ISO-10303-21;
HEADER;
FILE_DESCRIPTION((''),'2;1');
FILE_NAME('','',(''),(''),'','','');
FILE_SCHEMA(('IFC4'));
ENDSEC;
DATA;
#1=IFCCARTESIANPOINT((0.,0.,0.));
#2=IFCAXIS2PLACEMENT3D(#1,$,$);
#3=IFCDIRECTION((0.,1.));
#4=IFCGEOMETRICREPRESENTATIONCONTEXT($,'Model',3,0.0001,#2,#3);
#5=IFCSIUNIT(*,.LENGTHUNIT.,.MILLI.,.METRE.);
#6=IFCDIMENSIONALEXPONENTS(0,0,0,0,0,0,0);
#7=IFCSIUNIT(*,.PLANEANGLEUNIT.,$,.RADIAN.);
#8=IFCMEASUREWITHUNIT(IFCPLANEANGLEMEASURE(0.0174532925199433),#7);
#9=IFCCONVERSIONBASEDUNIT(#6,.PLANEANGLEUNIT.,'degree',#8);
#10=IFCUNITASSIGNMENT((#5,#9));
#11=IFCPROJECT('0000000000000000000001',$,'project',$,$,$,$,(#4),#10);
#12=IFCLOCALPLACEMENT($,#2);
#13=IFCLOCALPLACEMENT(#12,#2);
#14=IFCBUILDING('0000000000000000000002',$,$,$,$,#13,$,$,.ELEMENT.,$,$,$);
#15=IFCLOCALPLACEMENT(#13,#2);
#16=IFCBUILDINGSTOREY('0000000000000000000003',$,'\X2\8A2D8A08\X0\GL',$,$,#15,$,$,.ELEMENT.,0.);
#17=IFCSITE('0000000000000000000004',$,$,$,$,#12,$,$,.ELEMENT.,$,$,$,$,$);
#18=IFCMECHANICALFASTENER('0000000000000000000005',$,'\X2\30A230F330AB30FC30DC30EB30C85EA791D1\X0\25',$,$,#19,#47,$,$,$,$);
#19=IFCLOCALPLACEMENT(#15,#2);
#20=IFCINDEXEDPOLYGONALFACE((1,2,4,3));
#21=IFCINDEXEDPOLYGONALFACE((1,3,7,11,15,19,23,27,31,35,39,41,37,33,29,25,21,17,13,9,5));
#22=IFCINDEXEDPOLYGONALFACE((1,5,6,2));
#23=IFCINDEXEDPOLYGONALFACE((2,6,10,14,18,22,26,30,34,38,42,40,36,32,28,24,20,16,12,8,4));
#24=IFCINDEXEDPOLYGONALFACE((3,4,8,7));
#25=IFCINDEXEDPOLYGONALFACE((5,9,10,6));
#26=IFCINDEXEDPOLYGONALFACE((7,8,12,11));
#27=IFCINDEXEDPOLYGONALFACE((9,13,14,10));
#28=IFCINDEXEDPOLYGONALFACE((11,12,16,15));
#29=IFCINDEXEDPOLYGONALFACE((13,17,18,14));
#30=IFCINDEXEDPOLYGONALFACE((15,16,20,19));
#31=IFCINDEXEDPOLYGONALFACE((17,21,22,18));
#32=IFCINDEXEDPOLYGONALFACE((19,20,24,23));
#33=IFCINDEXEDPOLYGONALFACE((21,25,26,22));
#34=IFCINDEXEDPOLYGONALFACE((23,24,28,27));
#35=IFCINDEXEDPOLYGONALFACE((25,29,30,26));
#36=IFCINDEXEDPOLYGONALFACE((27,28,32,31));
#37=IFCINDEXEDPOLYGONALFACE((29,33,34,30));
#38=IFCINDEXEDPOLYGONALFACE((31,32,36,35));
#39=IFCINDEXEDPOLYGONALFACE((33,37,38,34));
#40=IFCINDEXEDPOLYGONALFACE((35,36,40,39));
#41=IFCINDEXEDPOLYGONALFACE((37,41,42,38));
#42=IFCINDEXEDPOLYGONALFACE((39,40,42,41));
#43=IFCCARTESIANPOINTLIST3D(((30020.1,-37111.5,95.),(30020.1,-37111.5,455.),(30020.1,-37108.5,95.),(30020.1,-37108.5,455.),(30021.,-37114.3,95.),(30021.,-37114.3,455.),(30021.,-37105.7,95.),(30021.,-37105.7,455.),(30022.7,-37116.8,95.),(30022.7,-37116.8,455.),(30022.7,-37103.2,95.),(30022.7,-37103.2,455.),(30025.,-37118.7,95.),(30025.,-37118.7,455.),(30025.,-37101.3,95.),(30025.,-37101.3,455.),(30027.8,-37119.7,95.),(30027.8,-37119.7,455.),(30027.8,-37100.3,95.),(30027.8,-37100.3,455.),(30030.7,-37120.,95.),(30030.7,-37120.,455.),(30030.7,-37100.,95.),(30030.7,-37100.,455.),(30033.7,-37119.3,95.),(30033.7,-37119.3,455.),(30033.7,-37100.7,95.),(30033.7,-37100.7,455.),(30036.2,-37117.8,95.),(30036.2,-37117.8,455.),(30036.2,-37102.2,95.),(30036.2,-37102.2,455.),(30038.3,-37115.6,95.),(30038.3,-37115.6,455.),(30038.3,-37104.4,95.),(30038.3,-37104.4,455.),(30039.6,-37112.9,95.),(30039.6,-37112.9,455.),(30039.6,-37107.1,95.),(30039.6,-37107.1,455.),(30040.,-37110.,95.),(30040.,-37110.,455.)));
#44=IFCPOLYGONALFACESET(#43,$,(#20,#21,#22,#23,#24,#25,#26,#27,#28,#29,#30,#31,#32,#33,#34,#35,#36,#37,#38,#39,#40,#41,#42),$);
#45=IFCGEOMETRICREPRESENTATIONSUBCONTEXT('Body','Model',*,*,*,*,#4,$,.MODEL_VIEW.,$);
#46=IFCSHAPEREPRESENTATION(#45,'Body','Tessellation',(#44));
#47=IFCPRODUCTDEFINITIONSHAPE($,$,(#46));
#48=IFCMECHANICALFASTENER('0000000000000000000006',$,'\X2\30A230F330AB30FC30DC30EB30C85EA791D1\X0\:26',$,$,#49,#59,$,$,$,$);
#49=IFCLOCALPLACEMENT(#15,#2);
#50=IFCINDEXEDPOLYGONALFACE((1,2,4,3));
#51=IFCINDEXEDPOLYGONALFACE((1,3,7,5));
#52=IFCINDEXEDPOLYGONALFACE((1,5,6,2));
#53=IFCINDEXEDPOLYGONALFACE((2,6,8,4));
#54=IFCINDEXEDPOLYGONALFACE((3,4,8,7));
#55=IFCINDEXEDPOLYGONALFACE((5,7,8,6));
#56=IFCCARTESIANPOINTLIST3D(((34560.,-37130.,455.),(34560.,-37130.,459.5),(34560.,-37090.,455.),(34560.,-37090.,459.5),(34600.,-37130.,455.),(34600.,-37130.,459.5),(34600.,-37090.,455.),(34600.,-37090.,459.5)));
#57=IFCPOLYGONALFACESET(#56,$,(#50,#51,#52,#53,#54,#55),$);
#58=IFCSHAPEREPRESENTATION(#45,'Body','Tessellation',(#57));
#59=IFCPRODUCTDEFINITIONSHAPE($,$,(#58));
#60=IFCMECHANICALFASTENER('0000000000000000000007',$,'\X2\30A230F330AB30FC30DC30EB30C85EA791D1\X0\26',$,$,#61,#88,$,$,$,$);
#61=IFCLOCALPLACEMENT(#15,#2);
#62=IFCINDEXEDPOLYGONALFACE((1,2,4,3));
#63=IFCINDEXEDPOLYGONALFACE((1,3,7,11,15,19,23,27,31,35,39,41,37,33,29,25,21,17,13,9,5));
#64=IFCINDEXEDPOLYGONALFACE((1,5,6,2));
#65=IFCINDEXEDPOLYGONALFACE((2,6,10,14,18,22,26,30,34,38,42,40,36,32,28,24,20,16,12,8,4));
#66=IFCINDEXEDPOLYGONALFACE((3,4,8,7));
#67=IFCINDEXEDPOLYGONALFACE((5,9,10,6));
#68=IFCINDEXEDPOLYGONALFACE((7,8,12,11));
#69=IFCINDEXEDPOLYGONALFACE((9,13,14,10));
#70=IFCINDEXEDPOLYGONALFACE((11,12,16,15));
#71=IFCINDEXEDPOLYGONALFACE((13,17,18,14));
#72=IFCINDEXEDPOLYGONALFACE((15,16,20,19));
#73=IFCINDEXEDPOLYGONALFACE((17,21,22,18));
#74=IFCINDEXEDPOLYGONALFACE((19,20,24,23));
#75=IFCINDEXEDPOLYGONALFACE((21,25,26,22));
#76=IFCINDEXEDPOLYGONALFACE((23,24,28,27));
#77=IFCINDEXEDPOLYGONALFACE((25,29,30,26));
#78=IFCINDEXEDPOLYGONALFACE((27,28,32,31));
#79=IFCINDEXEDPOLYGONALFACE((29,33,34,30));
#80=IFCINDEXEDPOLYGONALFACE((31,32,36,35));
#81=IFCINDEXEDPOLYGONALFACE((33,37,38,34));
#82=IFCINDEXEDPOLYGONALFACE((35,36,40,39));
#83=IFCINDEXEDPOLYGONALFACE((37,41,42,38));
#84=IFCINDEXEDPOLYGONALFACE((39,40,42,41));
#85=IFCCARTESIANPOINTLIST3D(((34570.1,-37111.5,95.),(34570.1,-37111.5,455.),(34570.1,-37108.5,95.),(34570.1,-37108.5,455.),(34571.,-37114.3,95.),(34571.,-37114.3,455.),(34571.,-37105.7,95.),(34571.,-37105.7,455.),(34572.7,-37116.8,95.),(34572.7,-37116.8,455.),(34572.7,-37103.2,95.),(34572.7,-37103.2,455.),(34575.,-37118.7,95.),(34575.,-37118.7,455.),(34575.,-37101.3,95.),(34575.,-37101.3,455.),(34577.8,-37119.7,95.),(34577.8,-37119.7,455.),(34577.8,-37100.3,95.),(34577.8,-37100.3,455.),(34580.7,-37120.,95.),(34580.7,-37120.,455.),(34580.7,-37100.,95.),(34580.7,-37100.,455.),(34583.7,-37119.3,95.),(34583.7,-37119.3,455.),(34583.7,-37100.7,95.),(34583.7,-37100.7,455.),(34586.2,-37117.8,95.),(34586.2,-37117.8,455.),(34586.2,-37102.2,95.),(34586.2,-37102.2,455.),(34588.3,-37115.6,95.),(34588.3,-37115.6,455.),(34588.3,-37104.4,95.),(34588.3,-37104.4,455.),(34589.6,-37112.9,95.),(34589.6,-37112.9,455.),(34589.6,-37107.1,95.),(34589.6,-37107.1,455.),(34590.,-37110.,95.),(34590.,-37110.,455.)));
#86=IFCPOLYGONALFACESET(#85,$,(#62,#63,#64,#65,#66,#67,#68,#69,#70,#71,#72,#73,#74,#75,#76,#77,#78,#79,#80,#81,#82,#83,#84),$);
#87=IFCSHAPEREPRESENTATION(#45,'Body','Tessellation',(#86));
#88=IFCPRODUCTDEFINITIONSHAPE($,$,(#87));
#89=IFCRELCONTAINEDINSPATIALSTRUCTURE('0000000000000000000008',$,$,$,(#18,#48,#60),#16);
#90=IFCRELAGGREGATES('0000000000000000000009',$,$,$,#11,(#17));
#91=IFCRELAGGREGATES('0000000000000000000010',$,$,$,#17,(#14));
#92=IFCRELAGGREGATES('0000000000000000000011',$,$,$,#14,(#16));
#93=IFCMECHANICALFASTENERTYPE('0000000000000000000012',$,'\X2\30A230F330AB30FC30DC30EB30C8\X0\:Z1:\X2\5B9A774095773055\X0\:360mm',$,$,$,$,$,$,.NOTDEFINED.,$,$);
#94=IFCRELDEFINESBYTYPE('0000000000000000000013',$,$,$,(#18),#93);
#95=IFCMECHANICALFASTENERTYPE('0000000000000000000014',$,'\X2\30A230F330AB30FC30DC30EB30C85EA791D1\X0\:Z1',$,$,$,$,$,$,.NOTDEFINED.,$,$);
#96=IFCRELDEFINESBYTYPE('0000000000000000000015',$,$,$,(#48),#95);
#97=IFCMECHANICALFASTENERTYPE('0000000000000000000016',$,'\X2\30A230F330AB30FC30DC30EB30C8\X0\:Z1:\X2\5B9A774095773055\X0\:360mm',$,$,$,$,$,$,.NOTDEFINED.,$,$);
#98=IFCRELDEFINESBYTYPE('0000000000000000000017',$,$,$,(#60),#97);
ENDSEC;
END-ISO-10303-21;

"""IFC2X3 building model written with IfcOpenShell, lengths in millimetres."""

from ifc_helpers import new_model, entity, si_unit, converted_unit, direction, frame, origin, origin_with_axes, origin_2d, place, context, subcontext, project, spatial, rectangle, circle, extrude, type_object, element, save


model = new_model("IFC2X3")

# Units and contexts
model_context = context("Model", 3, precision=0.0001, world=origin(), true_north=direction((0.0, 1.0)))
body_context = subcontext(model_context, "Body", "Model", "MODEL_VIEW")
ifc_project = project(units=[si_unit("LENGTHUNIT", "METRE", prefix="MILLI"), converted_unit("PLANEANGLEUNIT", "degree", entity("IfcPlaneAngleMeasure", 0.0174532925199433), si_unit("PLANEANGLEUNIT", "RADIAN"), dimensions=[0, 0, 0, 0, 0, 0, 0])], contexts=[model_context])

# Site, building, storey
site_placement = place(None, origin())
site = spatial("IfcSite", under=ifc_project, at=site_placement, CompositionType="ELEMENT")
building_placement = place(site_placement, origin())
building = spatial("IfcBuilding", under=site, at=building_placement, CompositionType="ELEMENT")
storey_placement = place(building_placement, origin())
storey = spatial("IfcBuildingStorey", under=building, at=storey_placement, Name="設計GL", CompositionType="ELEMENT", Elevation=0.0)

# Mechanical fasteners
mechanical_fastener_type_1 = type_object("IfcMechanicalFastenerType", Name="アンカーボルト:Z1:定着長さ:360mm")
mechanical_fastener_1_placement = place(storey_placement, frame((30030.0, -37110.0, 95.0)))
element("IfcMechanicalFastener", 1, at=mechanical_fastener_1_placement, inside=storey, type_object=mechanical_fastener_type_1, Name="アンカーボルト座金25", context=body_context, shape_type="SweptSolid", body=[
    extrude(circle(Radius=10.0, at=origin_2d()), origin_with_axes(), (0.0, 0.0, 1.0), 360.0),
])
mechanical_fastener_type_2 = type_object("IfcMechanicalFastenerType", Name="アンカーボルト座金:Z1")
mechanical_fastener_2_placement = place(storey_placement, frame((34580.0, -37110.0, 455.0)))
element("IfcMechanicalFastener", 2, at=mechanical_fastener_2_placement, inside=storey, type_object=mechanical_fastener_type_2, Name="アンカーボルト座金:26", context=body_context, shape_type="SweptSolid", body=[
    extrude(rectangle(XDim=40.0, YDim=40.0, at=origin_2d()), origin_with_axes(), (0.0, 0.0, 1.0), 4.5),
])
mechanical_fastener_type_3 = type_object("IfcMechanicalFastenerType", Name="アンカーボルト:Z1:定着長さ:360mm")
mechanical_fastener_3_placement = place(storey_placement, frame((34580.0, -37110.0, 95.0)))
element("IfcMechanicalFastener", 3, at=mechanical_fastener_3_placement, inside=storey, type_object=mechanical_fastener_type_3, Name="アンカーボルト座金26", context=body_context, shape_type="SweptSolid", body=[
    extrude(circle(Radius=10.0, at=origin_2d()), origin_with_axes(), (0.0, 0.0, 1.0), 360.0),
])

save(model, "model.ifc")
